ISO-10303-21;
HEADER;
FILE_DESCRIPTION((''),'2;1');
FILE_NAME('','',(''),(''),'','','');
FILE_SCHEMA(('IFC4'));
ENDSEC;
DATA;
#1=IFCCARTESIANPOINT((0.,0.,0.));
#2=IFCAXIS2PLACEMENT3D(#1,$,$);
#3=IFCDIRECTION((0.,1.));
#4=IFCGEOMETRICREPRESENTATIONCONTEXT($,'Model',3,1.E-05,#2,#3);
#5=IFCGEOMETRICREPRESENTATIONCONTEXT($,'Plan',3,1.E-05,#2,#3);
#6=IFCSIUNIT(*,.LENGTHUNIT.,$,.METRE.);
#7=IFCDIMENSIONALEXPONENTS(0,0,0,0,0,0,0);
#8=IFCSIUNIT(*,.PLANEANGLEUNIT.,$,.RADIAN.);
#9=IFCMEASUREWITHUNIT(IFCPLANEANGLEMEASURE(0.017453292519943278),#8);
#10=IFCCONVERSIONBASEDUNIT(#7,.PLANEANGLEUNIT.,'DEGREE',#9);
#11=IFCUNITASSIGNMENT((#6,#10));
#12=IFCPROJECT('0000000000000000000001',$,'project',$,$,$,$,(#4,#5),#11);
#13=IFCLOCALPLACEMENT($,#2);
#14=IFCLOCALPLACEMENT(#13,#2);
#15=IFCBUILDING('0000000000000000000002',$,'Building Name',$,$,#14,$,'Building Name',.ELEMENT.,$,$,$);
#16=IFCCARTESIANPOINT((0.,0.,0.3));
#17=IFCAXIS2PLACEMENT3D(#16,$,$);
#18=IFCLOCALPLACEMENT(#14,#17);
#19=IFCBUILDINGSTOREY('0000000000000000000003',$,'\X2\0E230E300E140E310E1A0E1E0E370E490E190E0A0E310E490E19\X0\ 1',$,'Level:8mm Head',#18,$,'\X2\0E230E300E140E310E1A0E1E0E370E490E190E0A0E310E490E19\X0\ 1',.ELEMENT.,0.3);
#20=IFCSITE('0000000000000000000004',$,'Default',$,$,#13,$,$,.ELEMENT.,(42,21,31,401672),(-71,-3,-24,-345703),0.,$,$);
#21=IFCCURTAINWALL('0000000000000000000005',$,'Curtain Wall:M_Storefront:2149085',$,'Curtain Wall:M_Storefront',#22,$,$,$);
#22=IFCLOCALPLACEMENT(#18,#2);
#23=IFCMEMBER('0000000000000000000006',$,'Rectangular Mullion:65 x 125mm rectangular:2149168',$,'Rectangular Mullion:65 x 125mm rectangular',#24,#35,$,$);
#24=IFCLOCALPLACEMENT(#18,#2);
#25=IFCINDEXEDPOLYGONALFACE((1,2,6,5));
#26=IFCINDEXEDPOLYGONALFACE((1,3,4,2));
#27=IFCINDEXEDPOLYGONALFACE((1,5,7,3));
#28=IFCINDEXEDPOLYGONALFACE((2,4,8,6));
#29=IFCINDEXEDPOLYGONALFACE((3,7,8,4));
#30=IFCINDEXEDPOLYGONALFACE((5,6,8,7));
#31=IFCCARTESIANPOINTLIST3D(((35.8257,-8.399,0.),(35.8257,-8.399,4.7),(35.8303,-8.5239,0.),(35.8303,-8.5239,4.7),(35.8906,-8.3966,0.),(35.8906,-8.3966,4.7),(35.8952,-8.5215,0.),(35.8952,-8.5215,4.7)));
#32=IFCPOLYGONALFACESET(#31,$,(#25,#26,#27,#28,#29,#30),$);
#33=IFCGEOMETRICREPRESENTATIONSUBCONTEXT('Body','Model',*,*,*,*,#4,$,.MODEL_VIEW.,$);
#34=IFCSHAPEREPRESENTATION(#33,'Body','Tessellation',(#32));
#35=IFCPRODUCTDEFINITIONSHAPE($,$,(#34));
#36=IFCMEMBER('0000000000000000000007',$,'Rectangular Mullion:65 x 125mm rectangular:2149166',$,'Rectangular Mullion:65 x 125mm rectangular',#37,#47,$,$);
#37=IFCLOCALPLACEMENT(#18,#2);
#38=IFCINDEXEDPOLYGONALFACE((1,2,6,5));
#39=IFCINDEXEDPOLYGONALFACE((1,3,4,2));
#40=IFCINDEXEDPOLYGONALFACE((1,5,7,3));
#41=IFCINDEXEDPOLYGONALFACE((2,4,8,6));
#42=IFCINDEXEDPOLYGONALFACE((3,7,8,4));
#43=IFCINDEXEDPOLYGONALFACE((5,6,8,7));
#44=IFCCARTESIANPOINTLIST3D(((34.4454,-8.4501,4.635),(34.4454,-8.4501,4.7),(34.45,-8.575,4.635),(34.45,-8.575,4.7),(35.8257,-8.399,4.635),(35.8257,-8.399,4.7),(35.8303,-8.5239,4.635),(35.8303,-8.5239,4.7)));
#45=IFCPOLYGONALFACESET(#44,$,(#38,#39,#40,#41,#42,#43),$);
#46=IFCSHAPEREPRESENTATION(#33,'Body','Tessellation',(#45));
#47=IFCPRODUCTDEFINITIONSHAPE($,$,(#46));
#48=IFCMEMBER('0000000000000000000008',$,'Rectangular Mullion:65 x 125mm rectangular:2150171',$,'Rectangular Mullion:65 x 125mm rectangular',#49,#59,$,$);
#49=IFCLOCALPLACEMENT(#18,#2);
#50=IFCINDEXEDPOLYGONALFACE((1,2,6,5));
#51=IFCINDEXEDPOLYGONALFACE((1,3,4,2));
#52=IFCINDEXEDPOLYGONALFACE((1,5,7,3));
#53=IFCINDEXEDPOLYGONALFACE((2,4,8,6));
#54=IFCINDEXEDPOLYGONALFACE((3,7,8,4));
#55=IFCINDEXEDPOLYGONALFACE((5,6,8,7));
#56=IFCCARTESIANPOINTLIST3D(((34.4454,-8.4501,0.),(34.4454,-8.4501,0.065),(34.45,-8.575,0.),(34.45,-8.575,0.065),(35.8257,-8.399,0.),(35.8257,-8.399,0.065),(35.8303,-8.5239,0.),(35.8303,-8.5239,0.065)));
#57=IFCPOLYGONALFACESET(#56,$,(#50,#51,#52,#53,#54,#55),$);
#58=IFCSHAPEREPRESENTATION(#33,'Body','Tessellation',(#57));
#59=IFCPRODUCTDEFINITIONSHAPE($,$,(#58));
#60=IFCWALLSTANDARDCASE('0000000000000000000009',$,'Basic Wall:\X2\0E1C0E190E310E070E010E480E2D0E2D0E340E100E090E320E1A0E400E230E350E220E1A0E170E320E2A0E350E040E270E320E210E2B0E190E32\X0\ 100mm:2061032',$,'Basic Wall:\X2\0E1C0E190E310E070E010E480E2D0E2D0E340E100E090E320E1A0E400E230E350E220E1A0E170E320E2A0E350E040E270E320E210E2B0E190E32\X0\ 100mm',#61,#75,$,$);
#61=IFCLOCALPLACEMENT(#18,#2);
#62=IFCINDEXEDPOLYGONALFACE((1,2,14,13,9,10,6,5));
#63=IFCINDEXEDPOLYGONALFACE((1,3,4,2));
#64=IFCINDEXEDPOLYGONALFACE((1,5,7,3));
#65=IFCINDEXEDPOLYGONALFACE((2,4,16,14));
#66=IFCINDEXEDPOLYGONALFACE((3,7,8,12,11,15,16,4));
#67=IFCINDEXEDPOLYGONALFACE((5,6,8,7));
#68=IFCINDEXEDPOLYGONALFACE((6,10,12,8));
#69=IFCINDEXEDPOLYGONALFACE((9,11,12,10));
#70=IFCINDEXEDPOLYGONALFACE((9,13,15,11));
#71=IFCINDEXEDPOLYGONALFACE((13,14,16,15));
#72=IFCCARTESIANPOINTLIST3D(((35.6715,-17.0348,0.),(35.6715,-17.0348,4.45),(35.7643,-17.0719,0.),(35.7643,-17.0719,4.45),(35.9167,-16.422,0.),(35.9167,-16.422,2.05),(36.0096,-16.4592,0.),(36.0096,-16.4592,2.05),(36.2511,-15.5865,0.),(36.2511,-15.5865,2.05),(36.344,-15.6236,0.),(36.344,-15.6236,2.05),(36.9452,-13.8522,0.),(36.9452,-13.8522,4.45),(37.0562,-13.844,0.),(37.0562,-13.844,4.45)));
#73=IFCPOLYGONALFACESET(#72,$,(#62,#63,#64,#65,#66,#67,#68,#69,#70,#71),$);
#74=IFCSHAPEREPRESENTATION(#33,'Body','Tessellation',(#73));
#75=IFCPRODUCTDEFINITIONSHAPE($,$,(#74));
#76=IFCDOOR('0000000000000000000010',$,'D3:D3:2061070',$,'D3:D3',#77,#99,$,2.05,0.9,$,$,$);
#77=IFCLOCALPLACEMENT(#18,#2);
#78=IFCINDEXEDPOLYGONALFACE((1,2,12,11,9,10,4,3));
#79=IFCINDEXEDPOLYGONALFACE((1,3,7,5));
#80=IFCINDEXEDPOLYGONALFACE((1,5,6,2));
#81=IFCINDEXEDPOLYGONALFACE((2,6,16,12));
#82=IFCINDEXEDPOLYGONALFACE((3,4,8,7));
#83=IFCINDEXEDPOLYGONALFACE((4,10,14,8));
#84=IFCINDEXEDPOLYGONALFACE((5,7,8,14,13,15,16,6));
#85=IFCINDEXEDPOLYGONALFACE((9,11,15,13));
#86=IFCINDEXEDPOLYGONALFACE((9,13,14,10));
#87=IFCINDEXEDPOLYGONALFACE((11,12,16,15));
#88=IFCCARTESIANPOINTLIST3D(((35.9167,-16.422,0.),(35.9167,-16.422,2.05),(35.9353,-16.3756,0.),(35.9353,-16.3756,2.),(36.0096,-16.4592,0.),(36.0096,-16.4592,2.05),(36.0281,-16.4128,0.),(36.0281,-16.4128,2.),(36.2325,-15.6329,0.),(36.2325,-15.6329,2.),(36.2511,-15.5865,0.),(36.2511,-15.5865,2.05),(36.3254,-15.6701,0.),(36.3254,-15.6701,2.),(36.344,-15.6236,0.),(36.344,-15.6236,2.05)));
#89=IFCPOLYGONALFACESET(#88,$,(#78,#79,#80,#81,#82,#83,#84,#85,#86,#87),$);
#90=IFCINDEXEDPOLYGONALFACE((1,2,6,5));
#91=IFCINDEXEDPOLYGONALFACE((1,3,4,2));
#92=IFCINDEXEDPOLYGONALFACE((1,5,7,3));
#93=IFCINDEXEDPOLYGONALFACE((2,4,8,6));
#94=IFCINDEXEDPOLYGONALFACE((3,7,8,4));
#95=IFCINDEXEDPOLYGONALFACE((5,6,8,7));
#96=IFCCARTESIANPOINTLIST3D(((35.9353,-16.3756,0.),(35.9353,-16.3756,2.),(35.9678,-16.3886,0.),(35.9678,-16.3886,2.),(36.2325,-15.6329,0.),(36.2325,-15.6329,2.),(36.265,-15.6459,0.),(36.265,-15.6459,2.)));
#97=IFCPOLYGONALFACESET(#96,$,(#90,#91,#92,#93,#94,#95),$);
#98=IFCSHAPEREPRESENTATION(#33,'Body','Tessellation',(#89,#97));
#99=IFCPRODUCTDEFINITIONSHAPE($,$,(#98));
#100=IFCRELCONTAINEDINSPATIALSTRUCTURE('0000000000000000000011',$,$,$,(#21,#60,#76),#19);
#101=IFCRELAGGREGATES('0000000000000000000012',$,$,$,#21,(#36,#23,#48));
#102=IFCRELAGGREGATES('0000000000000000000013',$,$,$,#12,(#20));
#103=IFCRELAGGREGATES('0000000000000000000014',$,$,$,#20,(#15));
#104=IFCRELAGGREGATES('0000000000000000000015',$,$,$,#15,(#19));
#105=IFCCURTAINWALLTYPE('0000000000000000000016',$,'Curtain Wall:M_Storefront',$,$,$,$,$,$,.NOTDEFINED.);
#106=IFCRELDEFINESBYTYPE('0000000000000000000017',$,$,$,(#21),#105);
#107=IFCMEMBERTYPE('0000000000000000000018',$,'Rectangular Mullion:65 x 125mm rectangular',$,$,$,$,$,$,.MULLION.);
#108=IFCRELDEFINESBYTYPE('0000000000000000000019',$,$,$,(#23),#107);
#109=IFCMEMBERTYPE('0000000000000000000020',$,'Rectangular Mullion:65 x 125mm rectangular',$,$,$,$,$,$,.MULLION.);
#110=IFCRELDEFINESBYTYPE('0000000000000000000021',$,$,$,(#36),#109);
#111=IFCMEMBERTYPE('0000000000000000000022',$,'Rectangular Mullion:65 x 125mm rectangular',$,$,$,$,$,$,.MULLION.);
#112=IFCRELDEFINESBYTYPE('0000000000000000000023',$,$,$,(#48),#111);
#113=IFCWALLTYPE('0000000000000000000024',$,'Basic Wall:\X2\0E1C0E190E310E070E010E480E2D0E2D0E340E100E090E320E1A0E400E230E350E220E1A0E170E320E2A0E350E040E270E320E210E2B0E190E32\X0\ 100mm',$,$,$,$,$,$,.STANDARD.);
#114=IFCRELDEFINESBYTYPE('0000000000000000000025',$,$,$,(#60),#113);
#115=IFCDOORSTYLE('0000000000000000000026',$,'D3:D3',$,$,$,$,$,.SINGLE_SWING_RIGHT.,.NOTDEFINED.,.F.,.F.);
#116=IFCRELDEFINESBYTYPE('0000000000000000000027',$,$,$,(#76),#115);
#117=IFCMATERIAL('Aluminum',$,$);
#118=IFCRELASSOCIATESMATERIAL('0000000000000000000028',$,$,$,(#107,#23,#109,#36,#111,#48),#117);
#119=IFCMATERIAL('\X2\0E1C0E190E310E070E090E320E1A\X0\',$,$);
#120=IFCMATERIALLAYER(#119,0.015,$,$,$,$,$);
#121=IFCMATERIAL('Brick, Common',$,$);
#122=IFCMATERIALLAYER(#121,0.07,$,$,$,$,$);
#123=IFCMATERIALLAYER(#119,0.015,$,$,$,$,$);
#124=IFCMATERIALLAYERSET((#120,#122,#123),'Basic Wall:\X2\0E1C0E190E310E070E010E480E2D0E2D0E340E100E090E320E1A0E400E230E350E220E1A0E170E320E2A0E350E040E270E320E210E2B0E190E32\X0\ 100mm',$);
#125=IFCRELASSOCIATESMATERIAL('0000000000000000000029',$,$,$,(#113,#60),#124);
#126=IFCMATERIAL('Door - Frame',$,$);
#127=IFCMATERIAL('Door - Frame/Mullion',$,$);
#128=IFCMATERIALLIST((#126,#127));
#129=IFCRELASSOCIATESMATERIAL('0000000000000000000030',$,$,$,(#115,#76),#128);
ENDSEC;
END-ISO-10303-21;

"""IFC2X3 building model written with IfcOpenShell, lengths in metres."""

from ifc_helpers import new_model, entity, si_unit, converted_unit, direction, frame, frame_2d, origin, origin_2d_with_axis, place, context, subcontext, project, spatial, polyline, rectangle, outline, extrude, clip, halfspace, source, transform, mapped, material, material_list, layer, layer_set, layer_usage, type_object, type_shapes, element, fill, aggregate, save


model = new_model("IFC2X3")

# Units and contexts
model_context = context("Model", 3, precision=1e-05, world=origin(), true_north=direction((0.0, 1.0)))
plan_context = context("Plan", 3, precision=1e-05, world=origin(), true_north=direction((0.0, 1.0)))
body_context = subcontext(model_context, "Body", "Model", "MODEL_VIEW")
ifc_project = project(units=[si_unit("LENGTHUNIT", "METRE"), converted_unit("PLANEANGLEUNIT", "DEGREE", entity("IfcPlaneAngleMeasure", 0.017453292519943278), si_unit("PLANEANGLEUNIT", "RADIAN"), dimensions=[0, 0, 0, 0, 0, 0, 0])], contexts=[model_context, plan_context])

# Site, building, storey
site_placement = place(None, origin())
site = spatial("IfcSite", under=ifc_project, at=site_placement, Name="Default", CompositionType="ELEMENT", RefLatitude=(42, 21, 31, 401672), RefLongitude=(-71, -3, -24, -345703), RefElevation=0.0)
building_placement = place(site_placement, origin())
building = spatial("IfcBuilding", under=site, at=building_placement, Name="Building Name", LongName="Building Name", CompositionType="ELEMENT")
storey_placement = place(building_placement, frame((0.0, 0.0, 0.3)))
storey = spatial("IfcBuildingStorey", under=building, at=storey_placement, Name="ระดับพื้นชั้น 1", ObjectType="Level:8mm Head", LongName="ระดับพื้นชั้น 1", CompositionType="ELEMENT", Elevation=0.3)

# Curtain wall, members
curtain_wall_type = type_object("IfcCurtainWallType", Name="Curtain Wall:M_Storefront", PredefinedType="NOTDEFINED")
curtain_wall_placement = place(storey_placement, frame((0.0, 0.0, -0.3)))
curtain_wall = element("IfcCurtainWall", 1, at=curtain_wall_placement, inside=storey, type_object=curtain_wall_type, Name="Curtain Wall:M_Storefront:2149085", ObjectType="Curtain Wall:M_Storefront")
ifc_material_1 = material(Name="Aluminum")
member_type_1 = type_object("IfcMemberType", Name="Rectangular Mullion:65 x 125mm rectangular", PredefinedType="MULLION", material=ifc_material_1)
shared_shape_1 = source(origin(), body_context, "Body", "SweptSolid", [
    extrude(rectangle(XDim=0.065, YDim=0.125, at=origin_2d_with_axis()), frame((-0.0325, 0.0, -4.7), z_axis=(0.0, 0.0, 1.0), x_axis=(-1.0, 0.0, 0.0)), (0.0, 0.0, 1.0), 4.7),
])
type_shapes(member_type_1, [shared_shape_1])
member_1_placement = place(curtain_wall_placement, frame((35.8929, -8.459, 0.3), z_axis=(0.0, 0.0, -1.0), x_axis=(0.999316, 0.036993, 0.0)))
member_1 = element("IfcMember", 2, at=member_1_placement, type_object=member_type_1, material=ifc_material_1, Name="Rectangular Mullion:65 x 125mm rectangular:2149168", ObjectType="Rectangular Mullion:65 x 125mm rectangular", context=body_context, shape_type="MappedRepresentation", body=[
    mapped(shared_shape_1, transform((0.0, 0.0, 0.0), scale=1.0)),
])
member_type_2 = type_object("IfcMemberType", Name="Rectangular Mullion:65 x 125mm rectangular", PredefinedType="MULLION", material=ifc_material_1)
shared_shape_2 = source(origin(), body_context, "Body", "SweptSolid", [
    extrude(rectangle(XDim=0.065, YDim=0.125, at=origin_2d_with_axis()), frame((-0.0325, 0.0, -1.3812), z_axis=(0.0, 0.0, 1.0), x_axis=(-1.0, 0.0, 0.0)), (0.0, 0.0, 1.0), 1.3812),
])
type_shapes(member_type_2, [shared_shape_2])
member_2_placement = place(curtain_wall_placement, frame((35.828, -8.4614, 5.0), z_axis=(0.999316, 0.036993, 0.0), x_axis=(0.0, 0.0, 1.0)))
member_2 = element("IfcMember", 3, at=member_2_placement, type_object=member_type_2, material=ifc_material_1, Name="Rectangular Mullion:65 x 125mm rectangular:2149166", ObjectType="Rectangular Mullion:65 x 125mm rectangular", context=body_context, shape_type="MappedRepresentation", body=[
    mapped(shared_shape_2, transform((0.0, 0.0, 0.0), scale=1.0)),
])
member_type_3 = type_object("IfcMemberType", Name="Rectangular Mullion:65 x 125mm rectangular", PredefinedType="MULLION", material=ifc_material_1)
shared_shape_3 = source(origin(), body_context, "Body", "SweptSolid", [
    extrude(rectangle(XDim=0.065, YDim=0.125, at=origin_2d_with_axis()), frame((-0.0325, 0.0, -1.3812), z_axis=(0.0, 0.0, 1.0), x_axis=(-1.0, 0.0, 0.0)), (0.0, 0.0, 1.0), 1.3812),
])
type_shapes(member_type_3, [shared_shape_3])
member_3_placement = place(curtain_wall_placement, frame((34.4477, -8.5125, 0.3), z_axis=(-0.999316, -0.036993, 0.0), x_axis=(0.0, 0.0, -1.0)))
member_3 = element("IfcMember", 4, at=member_3_placement, type_object=member_type_3, material=ifc_material_1, Name="Rectangular Mullion:65 x 125mm rectangular:2150171", ObjectType="Rectangular Mullion:65 x 125mm rectangular", context=body_context, shape_type="MappedRepresentation", body=[
    mapped(shared_shape_3, transform((0.0, 0.0, 0.0), scale=1.0)),
])
aggregate(curtain_wall, [member_2, member_1, member_3])

# Wall, opening, door
ifc_material_2 = material(Name="ผนังฉาบ")
ifc_layer_1 = layer(ifc_material_2, 0.015)
ifc_material_3 = material(Name="Brick, Common")
ifc_layer_2 = layer(ifc_material_3, 0.07)
ifc_layer_3 = layer(ifc_material_2, 0.015)
ifc_layer_set = layer_set([ifc_layer_1, ifc_layer_2, ifc_layer_3], Name="Basic Wall:ผนังก่ออิฐฉาบเรียบทาสีความหนา 100mm")
ifc_layer_usage_1 = layer_usage(ifc_layer_set, "AXIS2", "POSITIVE", -0.05)
wall_type = type_object("IfcWallType", Name="Basic Wall:ผนังก่ออิฐฉาบเรียบทาสีความหนา 100mm", PredefinedType="STANDARD", material=ifc_layer_set)
wall_1_placement = place(storey_placement, frame((35.7179, -17.0534, 0.0), z_axis=(0.0, 0.0, 1.0), x_axis=(0.371573, 0.928404, 0.0)))
wall_1 = element("IfcWallStandardCase", 5, at=wall_1_placement, inside=storey, type_object=wall_type, material=ifc_layer_usage_1, Name="Basic Wall:ผนังก่ออิฐฉาบเรียบทาสีความหนา 100mm:2061032", ObjectType="Basic Wall:ผนังก่ออิฐฉาบเรียบทาสีความหนา 100mm", context=body_context, shape_type="Clipping", body=[
    clip(extrude(outline(polyline([(3.4768, -0.05), (3.428, 0.05), (0.0, 0.05), (0.0, -0.05), (3.4768, -0.05)])), origin(), (0.0, 0.0, 1.0), 4.45), halfspace(frame((0.0, 0.0, -0.15)), True)),
])
opening_1_placement = place(wall_1_placement, frame((0.66, -0.05, 0.0)))
opening_1 = element("IfcOpeningElement", 6, at=opening_1_placement, cuts=wall_1, ObjectType="Opening", context=body_context, shape_type="SweptSolid", body=[
    extrude(rectangle(XDim=2.05, YDim=0.9, at=frame_2d((1.025, 0.45), x_axis=(1.0, 0.0))), frame((0.0, 0.0, 0.0), z_axis=(0.0, 1.0, 0.0), x_axis=(0.0, 0.0, 1.0)), (0.0, 0.0, 1.0), 0.1),
])
ifc_material_4 = material(Name="Door - Frame")
ifc_material_5 = material(Name="Door - Frame/Mullion")
ifc_material_list_1 = material_list([ifc_material_4, ifc_material_5])
door_style_1 = type_object("IfcDoorStyle", Name="D3:D3", ConstructionType="NOTDEFINED", OperationType="SINGLE_SWING_RIGHT", ParameterTakesPrecedence=False, Sizeable=False, material=ifc_material_list_1)
shared_shape_4 = source(origin(), body_context, "Body", "SweptSolid", [
    extrude(outline(polyline([(-0.45, -1.0125), (-0.4, -1.0125), (-0.4, 0.9875), (0.4, 0.9875), (0.4, -1.0125), (0.45, -1.0125), (0.45, 1.0375), (-0.45, 1.0375), (-0.45, -1.0125)])), frame((0.45, 0.1, 1.0125), z_axis=(0.0, -1.0, 0.0), x_axis=(1.0, 0.0, 0.0)), (0.0, 0.0, 1.0), 0.1),
    extrude(rectangle(XDim=0.035, YDim=0.8, at=origin_2d_with_axis()), frame((0.45, 0.0825, 0.0), z_axis=(0.0, 0.0, 1.0), x_axis=(0.0, -1.0, 0.0)), (0.0, 0.0, 1.0), 2.0),
])
type_shapes(door_style_1, [shared_shape_4])
door_1_placement = place(opening_1_placement, origin())
door_1 = element("IfcDoor", 7, at=door_1_placement, inside=storey, type_object=door_style_1, material=ifc_material_list_1, Name="D3:D3:2061070", ObjectType="D3:D3", OverallHeight=2.05, OverallWidth=0.9, context=body_context, shape_type="MappedRepresentation", body=[
    mapped(shared_shape_4, transform((0.0, 0.0, 0.0), scale=1.0)),
])
fill(opening_1, door_1)

save(model, "model.ifc")
